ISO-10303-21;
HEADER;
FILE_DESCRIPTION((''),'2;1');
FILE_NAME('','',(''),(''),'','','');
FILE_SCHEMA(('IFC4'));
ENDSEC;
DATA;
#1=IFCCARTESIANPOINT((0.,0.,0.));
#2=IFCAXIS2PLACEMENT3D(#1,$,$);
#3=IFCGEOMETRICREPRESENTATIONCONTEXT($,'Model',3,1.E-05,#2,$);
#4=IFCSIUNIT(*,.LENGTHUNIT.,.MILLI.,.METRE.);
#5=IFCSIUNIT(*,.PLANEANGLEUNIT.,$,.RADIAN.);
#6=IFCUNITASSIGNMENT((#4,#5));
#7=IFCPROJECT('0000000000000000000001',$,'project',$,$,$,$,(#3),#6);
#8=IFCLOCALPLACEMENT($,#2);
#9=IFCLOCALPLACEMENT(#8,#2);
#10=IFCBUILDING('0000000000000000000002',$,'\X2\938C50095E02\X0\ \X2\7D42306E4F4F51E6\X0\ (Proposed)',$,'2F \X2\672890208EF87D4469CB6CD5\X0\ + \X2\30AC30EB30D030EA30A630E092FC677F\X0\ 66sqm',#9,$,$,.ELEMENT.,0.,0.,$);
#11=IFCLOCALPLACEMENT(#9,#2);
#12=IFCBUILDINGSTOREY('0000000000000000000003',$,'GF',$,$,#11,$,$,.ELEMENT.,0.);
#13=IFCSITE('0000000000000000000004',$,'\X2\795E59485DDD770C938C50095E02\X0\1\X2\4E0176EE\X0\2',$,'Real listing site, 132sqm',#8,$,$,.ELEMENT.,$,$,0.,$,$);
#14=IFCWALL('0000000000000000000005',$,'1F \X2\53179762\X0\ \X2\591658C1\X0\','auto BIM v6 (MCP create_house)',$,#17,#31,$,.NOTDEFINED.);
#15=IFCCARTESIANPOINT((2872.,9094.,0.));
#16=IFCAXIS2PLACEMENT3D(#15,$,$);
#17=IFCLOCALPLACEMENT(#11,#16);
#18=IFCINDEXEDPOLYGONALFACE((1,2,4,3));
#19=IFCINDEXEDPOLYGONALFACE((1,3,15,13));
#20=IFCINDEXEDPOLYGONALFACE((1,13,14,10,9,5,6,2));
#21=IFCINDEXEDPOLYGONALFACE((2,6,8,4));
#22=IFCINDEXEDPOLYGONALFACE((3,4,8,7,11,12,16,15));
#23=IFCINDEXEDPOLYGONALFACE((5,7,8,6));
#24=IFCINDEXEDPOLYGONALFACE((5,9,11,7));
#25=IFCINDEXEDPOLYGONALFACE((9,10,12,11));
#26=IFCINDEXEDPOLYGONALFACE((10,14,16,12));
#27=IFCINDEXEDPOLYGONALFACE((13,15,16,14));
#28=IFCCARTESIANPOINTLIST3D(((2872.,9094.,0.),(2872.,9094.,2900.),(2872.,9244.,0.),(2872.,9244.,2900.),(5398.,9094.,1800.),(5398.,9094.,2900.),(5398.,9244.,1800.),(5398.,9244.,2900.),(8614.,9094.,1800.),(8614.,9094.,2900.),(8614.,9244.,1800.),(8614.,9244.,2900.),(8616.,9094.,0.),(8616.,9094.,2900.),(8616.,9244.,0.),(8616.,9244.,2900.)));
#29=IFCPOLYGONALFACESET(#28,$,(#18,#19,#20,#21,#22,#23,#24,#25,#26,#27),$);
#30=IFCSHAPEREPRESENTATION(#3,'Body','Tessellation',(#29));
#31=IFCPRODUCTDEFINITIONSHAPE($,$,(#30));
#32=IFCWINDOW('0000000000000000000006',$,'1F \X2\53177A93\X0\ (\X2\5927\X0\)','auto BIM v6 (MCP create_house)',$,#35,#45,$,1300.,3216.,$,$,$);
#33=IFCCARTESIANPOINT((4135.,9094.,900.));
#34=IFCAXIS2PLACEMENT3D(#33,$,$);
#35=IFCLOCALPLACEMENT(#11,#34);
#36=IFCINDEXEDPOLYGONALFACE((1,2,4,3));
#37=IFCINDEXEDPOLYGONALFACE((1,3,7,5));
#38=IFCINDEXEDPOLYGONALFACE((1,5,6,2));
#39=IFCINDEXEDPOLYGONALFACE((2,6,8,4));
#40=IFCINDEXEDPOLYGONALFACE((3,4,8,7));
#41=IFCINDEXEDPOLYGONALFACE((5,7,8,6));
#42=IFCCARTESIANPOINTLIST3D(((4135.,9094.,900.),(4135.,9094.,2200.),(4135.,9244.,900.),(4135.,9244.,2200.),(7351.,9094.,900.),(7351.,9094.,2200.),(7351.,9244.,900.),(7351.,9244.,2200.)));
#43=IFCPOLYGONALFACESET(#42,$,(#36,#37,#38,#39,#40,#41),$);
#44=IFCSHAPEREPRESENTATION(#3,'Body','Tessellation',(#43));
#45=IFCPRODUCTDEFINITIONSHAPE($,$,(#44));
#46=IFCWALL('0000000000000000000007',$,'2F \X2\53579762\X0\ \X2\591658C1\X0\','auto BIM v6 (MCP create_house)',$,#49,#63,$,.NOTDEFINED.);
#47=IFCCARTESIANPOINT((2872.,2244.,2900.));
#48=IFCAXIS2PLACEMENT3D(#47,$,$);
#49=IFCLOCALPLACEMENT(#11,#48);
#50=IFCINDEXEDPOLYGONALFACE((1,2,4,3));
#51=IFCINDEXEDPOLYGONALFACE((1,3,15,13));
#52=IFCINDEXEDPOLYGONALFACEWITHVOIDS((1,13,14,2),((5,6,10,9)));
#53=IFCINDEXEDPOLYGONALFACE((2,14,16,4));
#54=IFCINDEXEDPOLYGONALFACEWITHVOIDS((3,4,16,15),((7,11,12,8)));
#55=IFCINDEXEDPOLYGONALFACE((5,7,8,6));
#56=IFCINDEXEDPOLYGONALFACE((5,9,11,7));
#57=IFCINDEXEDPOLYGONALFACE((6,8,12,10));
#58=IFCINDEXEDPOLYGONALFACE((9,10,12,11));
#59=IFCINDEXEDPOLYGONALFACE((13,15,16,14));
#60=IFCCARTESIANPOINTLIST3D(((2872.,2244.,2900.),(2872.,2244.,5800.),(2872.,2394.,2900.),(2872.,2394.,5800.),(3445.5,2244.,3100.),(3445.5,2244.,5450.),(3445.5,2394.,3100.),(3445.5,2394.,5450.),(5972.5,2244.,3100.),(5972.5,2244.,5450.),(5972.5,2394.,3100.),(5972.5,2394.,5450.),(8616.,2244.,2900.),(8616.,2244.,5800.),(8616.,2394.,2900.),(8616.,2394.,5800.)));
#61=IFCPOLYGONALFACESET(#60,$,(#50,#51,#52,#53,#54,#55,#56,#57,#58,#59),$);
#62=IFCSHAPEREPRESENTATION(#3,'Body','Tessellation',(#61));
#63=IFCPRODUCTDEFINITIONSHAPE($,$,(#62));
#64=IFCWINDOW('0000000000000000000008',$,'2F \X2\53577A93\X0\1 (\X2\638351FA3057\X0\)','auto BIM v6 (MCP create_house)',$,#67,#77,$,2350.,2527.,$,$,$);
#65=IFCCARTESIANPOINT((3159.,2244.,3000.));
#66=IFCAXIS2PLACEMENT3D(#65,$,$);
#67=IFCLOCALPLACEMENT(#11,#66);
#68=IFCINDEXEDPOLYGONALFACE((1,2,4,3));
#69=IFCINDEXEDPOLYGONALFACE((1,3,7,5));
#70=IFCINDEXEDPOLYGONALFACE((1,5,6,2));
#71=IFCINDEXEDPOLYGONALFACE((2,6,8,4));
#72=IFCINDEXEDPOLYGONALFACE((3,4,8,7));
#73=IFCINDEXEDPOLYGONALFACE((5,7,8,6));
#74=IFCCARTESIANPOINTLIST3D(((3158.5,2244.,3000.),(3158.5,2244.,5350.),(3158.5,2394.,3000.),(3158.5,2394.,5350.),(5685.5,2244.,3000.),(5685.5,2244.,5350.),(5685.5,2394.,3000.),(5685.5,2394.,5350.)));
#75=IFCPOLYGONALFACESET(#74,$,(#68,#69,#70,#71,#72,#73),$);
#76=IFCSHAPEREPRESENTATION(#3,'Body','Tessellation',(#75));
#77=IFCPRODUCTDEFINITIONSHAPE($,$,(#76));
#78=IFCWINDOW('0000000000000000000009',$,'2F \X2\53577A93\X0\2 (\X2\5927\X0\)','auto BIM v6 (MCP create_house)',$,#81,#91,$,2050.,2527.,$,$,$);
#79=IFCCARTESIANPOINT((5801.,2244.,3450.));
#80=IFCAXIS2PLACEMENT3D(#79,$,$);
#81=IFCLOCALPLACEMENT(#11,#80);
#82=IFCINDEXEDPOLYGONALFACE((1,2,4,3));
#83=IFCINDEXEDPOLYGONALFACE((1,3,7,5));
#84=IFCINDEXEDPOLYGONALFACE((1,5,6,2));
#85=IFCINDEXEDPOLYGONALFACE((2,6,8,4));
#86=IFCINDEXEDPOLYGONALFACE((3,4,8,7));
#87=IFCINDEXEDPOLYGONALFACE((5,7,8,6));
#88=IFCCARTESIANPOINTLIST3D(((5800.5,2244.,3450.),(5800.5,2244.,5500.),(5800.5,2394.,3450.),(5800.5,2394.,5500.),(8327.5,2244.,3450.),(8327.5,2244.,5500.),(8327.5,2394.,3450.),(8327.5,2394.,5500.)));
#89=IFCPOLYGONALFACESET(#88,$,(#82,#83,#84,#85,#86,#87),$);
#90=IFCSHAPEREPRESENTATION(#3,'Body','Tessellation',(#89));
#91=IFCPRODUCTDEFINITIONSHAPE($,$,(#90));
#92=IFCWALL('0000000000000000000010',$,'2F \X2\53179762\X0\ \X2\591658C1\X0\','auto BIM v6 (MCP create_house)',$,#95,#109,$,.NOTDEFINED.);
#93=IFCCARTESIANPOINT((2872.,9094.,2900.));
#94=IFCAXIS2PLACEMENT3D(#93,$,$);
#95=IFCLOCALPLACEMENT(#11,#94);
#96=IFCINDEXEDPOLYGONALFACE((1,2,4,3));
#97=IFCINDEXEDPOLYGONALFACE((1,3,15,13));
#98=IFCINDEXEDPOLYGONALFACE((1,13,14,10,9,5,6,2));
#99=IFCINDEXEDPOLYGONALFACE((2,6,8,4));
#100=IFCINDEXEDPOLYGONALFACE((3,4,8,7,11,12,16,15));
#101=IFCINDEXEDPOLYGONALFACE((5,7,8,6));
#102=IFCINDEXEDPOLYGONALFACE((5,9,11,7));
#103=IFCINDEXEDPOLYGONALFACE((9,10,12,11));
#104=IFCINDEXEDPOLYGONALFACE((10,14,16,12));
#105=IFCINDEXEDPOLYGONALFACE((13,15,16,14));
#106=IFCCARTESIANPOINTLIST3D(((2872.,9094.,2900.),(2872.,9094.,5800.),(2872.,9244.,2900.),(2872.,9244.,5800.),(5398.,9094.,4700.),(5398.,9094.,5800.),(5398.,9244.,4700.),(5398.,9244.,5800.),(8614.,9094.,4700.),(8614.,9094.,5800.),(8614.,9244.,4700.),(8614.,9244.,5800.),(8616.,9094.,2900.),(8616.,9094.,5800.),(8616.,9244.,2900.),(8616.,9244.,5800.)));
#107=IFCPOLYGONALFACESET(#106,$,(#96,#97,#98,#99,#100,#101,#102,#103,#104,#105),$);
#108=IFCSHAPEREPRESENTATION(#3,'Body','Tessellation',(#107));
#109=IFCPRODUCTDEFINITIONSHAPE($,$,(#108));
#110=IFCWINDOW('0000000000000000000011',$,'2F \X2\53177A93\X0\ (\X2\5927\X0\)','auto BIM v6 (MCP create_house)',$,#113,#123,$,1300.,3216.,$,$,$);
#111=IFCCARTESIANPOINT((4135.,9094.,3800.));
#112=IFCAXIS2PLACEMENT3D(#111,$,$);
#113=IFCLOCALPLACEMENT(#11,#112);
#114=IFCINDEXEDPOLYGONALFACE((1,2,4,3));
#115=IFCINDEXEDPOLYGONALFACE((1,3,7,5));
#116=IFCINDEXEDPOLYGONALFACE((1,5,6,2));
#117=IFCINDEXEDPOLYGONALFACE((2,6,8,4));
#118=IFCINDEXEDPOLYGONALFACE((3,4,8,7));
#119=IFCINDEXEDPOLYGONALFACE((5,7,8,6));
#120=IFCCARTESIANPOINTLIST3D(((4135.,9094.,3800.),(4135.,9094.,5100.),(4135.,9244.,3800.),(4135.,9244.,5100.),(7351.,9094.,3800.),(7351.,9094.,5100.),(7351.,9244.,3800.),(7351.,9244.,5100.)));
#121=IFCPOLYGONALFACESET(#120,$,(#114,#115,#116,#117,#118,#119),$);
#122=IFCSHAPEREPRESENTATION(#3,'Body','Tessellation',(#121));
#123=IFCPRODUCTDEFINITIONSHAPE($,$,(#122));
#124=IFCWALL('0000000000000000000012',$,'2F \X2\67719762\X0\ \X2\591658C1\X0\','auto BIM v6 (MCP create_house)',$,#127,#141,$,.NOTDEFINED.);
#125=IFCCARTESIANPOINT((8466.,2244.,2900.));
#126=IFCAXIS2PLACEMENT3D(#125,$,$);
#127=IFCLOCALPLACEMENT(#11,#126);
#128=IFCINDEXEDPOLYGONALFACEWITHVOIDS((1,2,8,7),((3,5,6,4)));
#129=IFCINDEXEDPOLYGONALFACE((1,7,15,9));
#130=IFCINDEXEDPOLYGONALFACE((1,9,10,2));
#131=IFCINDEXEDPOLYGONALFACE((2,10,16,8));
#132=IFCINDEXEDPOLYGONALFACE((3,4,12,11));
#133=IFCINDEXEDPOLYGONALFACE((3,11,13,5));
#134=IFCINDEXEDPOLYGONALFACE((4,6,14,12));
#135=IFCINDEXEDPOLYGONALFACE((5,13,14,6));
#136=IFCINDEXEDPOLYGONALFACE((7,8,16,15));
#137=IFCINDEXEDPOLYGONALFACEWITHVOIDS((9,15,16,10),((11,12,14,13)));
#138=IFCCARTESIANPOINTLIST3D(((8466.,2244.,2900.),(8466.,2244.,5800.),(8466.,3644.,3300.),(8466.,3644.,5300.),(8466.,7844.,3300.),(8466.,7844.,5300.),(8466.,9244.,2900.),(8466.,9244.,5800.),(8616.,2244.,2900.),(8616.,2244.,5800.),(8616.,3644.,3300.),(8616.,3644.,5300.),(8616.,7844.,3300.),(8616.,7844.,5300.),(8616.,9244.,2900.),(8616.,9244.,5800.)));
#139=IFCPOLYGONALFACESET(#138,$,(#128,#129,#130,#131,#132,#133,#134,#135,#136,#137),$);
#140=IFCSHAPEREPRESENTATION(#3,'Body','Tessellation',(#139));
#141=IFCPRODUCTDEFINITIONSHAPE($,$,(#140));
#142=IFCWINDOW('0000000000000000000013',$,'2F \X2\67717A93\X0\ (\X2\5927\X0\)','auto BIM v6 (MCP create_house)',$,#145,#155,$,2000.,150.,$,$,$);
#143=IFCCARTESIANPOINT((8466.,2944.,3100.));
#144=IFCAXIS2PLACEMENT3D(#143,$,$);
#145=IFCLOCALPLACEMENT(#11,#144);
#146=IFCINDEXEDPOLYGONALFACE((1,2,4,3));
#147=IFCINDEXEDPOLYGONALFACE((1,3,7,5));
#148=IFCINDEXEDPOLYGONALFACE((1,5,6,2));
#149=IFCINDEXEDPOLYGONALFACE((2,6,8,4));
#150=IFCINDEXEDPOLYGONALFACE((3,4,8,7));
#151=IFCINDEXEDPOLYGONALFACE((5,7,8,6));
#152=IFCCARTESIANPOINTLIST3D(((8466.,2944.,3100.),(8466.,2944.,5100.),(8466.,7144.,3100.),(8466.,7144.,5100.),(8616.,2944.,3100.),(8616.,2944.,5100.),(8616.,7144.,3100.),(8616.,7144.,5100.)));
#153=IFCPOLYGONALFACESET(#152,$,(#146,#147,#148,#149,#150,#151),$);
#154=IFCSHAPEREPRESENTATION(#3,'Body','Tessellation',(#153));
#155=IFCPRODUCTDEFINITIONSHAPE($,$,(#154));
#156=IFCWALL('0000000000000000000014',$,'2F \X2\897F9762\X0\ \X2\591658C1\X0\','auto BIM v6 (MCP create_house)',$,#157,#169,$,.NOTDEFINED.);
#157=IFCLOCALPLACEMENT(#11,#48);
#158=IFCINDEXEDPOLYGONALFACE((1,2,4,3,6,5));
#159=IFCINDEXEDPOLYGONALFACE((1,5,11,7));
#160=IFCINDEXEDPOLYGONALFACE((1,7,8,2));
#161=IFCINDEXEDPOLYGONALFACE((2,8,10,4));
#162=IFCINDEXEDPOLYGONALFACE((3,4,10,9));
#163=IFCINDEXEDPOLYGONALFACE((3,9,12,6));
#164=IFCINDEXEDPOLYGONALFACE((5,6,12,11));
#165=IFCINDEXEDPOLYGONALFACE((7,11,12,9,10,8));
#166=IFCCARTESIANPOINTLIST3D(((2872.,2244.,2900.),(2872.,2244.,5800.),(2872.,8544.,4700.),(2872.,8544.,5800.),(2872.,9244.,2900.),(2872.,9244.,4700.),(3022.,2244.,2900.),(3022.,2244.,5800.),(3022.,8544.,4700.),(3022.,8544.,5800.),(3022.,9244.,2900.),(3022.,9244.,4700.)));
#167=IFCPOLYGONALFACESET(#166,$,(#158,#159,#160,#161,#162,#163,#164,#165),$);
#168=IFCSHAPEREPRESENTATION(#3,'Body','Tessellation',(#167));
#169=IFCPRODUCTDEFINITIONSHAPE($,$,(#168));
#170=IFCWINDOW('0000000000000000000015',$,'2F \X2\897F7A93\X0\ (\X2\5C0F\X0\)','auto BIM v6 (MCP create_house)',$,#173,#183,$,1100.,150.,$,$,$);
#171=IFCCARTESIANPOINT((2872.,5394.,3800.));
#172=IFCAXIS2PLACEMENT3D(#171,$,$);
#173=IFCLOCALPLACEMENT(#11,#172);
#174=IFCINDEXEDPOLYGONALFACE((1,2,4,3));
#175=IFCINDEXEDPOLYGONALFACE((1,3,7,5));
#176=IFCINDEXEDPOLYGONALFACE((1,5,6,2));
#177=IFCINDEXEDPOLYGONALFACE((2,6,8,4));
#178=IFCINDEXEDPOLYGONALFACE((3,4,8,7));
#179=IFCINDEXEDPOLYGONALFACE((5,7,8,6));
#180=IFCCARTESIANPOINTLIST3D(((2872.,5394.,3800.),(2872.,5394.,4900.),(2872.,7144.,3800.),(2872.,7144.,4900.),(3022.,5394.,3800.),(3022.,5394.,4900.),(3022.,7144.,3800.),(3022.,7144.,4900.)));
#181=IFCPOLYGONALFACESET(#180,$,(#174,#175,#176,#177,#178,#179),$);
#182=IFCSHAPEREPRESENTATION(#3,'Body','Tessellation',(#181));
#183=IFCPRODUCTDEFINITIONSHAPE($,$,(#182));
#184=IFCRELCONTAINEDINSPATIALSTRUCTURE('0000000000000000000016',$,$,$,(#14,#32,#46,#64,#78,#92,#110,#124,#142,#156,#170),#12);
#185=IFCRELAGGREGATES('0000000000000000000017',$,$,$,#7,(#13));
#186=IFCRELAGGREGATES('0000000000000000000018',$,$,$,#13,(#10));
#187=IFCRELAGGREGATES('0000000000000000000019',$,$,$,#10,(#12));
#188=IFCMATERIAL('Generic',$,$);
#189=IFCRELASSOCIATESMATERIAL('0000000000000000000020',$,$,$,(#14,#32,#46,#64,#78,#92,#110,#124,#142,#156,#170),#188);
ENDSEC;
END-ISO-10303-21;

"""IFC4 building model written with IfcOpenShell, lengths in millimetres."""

from ifc_helpers import new_model, si_unit, frame, frame_2d, origin, place, context, project, spatial, rectangle, extrude, material, element, fill, save


model = new_model("IFC4")

# Units and contexts
model_context = context("Model", 3, precision=1e-05, world=origin())
ifc_project = project(units=[si_unit("LENGTHUNIT", "METRE", prefix="MILLI"), si_unit("PLANEANGLEUNIT", "RADIAN")], contexts=[model_context])

# Site, building, storey
site_placement = place(None, origin())
site = spatial("IfcSite", under=ifc_project, at=site_placement, Name="神奈川県鎌倉市1丁目2", ObjectType="Real listing site, 132sqm", CompositionType="ELEMENT", RefElevation=0.0)
building_placement = place(site_placement, origin())
building = spatial("IfcBuilding", under=site, at=building_placement, Name="鎌倉市 終の住処 (Proposed)", ObjectType="2F 木造軸組構法 + ガルバリウム鋼板 66sqm", CompositionType="ELEMENT", ElevationOfRefHeight=0.0, ElevationOfTerrain=0.0)
storey_placement = place(building_placement, origin())
storey = spatial("IfcBuildingStorey", under=building, at=storey_placement, Name="GF", CompositionType="ELEMENT", Elevation=0.0)

# Wall, opening, window
ifc_material = material(Name="Generic")
wall_1_placement = place(storey_placement, frame((2872.0, 9094.0, 0.0)))
wall_1 = element("IfcWall", 1, at=wall_1_placement, inside=storey, material=ifc_material, Name="1F 北面 外壁", Description="auto BIM v6 (MCP create_house)", PredefinedType="NOTDEFINED", context=model_context, shape_type="SweptSolid", body=[
    extrude(rectangle(XDim=5744.0, YDim=150.0, at=frame_2d((2872.0, 75.0))), frame((2872.0, 9094.0, 0.0)), (0.0, 0.0, 1.0), 2900.0),
])
opening_1_placement = place(storey_placement, frame((4135.0, 9094.0, 900.0)))
opening_1 = element("IfcOpeningElement", 2, at=opening_1_placement, cuts=wall_1, PredefinedType="NOTDEFINED", context=model_context, shape_type="SweptSolid", body=[
    extrude(rectangle(XDim=3216.0, YDim=150.0, at=frame_2d((1608.0, 75.0))), frame((4135.0, 9094.0, 900.0)), (0.0, 0.0, 1.0), 1300.0),
])
window_1_placement = place(storey_placement, frame((4135.0, 9094.0, 900.0)))
window_1 = element("IfcWindow", 3, at=window_1_placement, inside=storey, material=ifc_material, Name="1F 北窓 (大)", Description="auto BIM v6 (MCP create_house)", OverallHeight=1300.0, OverallWidth=3216.0, context=model_context, shape_type="SweptSolid", body=[
    extrude(rectangle(XDim=3216.0, YDim=150.0, at=frame_2d((1608.0, 75.0))), frame((4135.0, 9094.0, 900.0)), (0.0, 0.0, 1.0), 1300.0),
])
fill(opening_1, window_1)

# Wall, openings, windows
wall_2_placement = place(storey_placement, frame((2872.0, 2244.0, 2900.0)))
wall_2 = element("IfcWall", 4, at=wall_2_placement, inside=storey, material=ifc_material, Name="2F 南面 外壁", Description="auto BIM v6 (MCP create_house)", PredefinedType="NOTDEFINED", context=model_context, shape_type="SweptSolid", body=[
    extrude(rectangle(XDim=5744.0, YDim=150.0, at=frame_2d((2872.0, 75.0))), frame((2872.0, 2244.0, 2900.0)), (0.0, 0.0, 1.0), 2900.0),
])
opening_2_placement = place(storey_placement, frame((3159.0, 2244.0, 3000.0)))
opening_2 = element("IfcOpeningElement", 5, at=opening_2_placement, cuts=wall_2, PredefinedType="NOTDEFINED", context=model_context, shape_type="SweptSolid", body=[
    extrude(rectangle(XDim=2527.0, YDim=150.0, at=frame_2d((1263.0, 75.0))), frame((3159.0, 2244.0, 3000.0)), (0.0, 0.0, 1.0), 2350.0),
])
opening_3_placement = place(storey_placement, frame((5801.0, 2244.0, 3450.0)))
opening_3 = element("IfcOpeningElement", 6, at=opening_3_placement, cuts=wall_2, PredefinedType="NOTDEFINED", context=model_context, shape_type="SweptSolid", body=[
    extrude(rectangle(XDim=2527.0, YDim=150.0, at=frame_2d((1263.0, 75.0))), frame((5801.0, 2244.0, 3450.0)), (0.0, 0.0, 1.0), 2050.0),
])
window_2_placement = place(storey_placement, frame((3159.0, 2244.0, 3000.0)))
window_2 = element("IfcWindow", 7, at=window_2_placement, inside=storey, material=ifc_material, Name="2F 南窓1 (掃出し)", Description="auto BIM v6 (MCP create_house)", OverallHeight=2350.0, OverallWidth=2527.0, context=model_context, shape_type="SweptSolid", body=[
    extrude(rectangle(XDim=2527.0, YDim=150.0, at=frame_2d((1263.0, 75.0))), frame((3159.0, 2244.0, 3000.0)), (0.0, 0.0, 1.0), 2350.0),
])
fill(opening_2, window_2)
window_3_placement = place(storey_placement, frame((5801.0, 2244.0, 3450.0)))
window_3 = element("IfcWindow", 8, at=window_3_placement, inside=storey, material=ifc_material, Name="2F 南窓2 (大)", Description="auto BIM v6 (MCP create_house)", OverallHeight=2050.0, OverallWidth=2527.0, context=model_context, shape_type="SweptSolid", body=[
    extrude(rectangle(XDim=2527.0, YDim=150.0, at=frame_2d((1263.0, 75.0))), frame((5801.0, 2244.0, 3450.0)), (0.0, 0.0, 1.0), 2050.0),
])
fill(opening_3, window_3)

# Walls, openings, windows
wall_3_placement = place(storey_placement, frame((2872.0, 9094.0, 2900.0)))
wall_3 = element("IfcWall", 9, at=wall_3_placement, inside=storey, material=ifc_material, Name="2F 北面 外壁", Description="auto BIM v6 (MCP create_house)", PredefinedType="NOTDEFINED", context=model_context, shape_type="SweptSolid", body=[
    extrude(rectangle(XDim=5744.0, YDim=150.0, at=frame_2d((2872.0, 75.0))), frame((2872.0, 9094.0, 2900.0)), (0.0, 0.0, 1.0), 2900.0),
])
opening_4_placement = place(storey_placement, frame((4135.0, 9094.0, 3800.0)))
opening_4 = element("IfcOpeningElement", 10, at=opening_4_placement, cuts=wall_3, PredefinedType="NOTDEFINED", context=model_context, shape_type="SweptSolid", body=[
    extrude(rectangle(XDim=3216.0, YDim=150.0, at=frame_2d((1608.0, 75.0))), frame((4135.0, 9094.0, 3800.0)), (0.0, 0.0, 1.0), 1300.0),
])
window_4_placement = place(storey_placement, frame((4135.0, 9094.0, 3800.0)))
window_4 = element("IfcWindow", 11, at=window_4_placement, inside=storey, material=ifc_material, Name="2F 北窓 (大)", Description="auto BIM v6 (MCP create_house)", OverallHeight=1300.0, OverallWidth=3216.0, context=model_context, shape_type="SweptSolid", body=[
    extrude(rectangle(XDim=3216.0, YDim=150.0, at=frame_2d((1608.0, 75.0))), frame((4135.0, 9094.0, 3800.0)), (0.0, 0.0, 1.0), 1300.0),
])
fill(opening_4, window_4)
wall_4_placement = place(storey_placement, frame((8466.0, 2244.0, 2900.0)))
wall_4 = element("IfcWall", 12, at=wall_4_placement, inside=storey, material=ifc_material, Name="2F 東面 外壁", Description="auto BIM v6 (MCP create_house)", PredefinedType="NOTDEFINED", context=model_context, shape_type="SweptSolid", body=[
    extrude(rectangle(XDim=150.0, YDim=7000.0, at=frame_2d((75.0, 3500.0))), frame((8466.0, 2244.0, 2900.0)), (0.0, 0.0, 1.0), 2900.0),
])
opening_5_placement = place(storey_placement, frame((8466.0, 2944.0, 3100.0)))
opening_5 = element("IfcOpeningElement", 13, at=opening_5_placement, cuts=wall_4, PredefinedType="NOTDEFINED", context=model_context, shape_type="SweptSolid", body=[
    extrude(rectangle(XDim=150.0, YDim=4200.0, at=frame_2d((75.0, 2100.0))), frame((8466.0, 2944.0, 3100.0)), (0.0, 0.0, 1.0), 2000.0),
])
window_5_placement = place(storey_placement, frame((8466.0, 2944.0, 3100.0)))
window_5 = element("IfcWindow", 14, at=window_5_placement, inside=storey, material=ifc_material, Name="2F 東窓 (大)", Description="auto BIM v6 (MCP create_house)", OverallHeight=2000.0, OverallWidth=150.0, context=model_context, shape_type="SweptSolid", body=[
    extrude(rectangle(XDim=150.0, YDim=4200.0, at=frame_2d((75.0, 2100.0))), frame((8466.0, 2944.0, 3100.0)), (0.0, 0.0, 1.0), 2000.0),
])
fill(opening_5, window_5)
wall_5_placement = place(storey_placement, frame((2872.0, 2244.0, 2900.0)))
wall_5 = element("IfcWall", 15, at=wall_5_placement, inside=storey, material=ifc_material, Name="2F 西面 外壁", Description="auto BIM v6 (MCP create_house)", PredefinedType="NOTDEFINED", context=model_context, shape_type="SweptSolid", body=[
    extrude(rectangle(XDim=150.0, YDim=7000.0, at=frame_2d((75.0, 3500.0))), frame((2872.0, 2244.0, 2900.0)), (0.0, 0.0, 1.0), 2900.0),
])
opening_6_placement = place(storey_placement, frame((2872.0, 5394.0, 3800.0)))
opening_6 = element("IfcOpeningElement", 16, at=opening_6_placement, cuts=wall_5, PredefinedType="NOTDEFINED", context=model_context, shape_type="SweptSolid", body=[
    extrude(rectangle(XDim=150.0, YDim=1750.0, at=frame_2d((75.0, 875.0))), frame((2872.0, 5394.0, 3800.0)), (0.0, 0.0, 1.0), 1100.0),
])
window_6_placement = place(storey_placement, frame((2872.0, 5394.0, 3800.0)))
window_6 = element("IfcWindow", 17, at=window_6_placement, inside=storey, material=ifc_material, Name="2F 西窓 (小)", Description="auto BIM v6 (MCP create_house)", OverallHeight=1100.0, OverallWidth=150.0, context=model_context, shape_type="SweptSolid", body=[
    extrude(rectangle(XDim=150.0, YDim=1750.0, at=frame_2d((75.0, 875.0))), frame((2872.0, 5394.0, 3800.0)), (0.0, 0.0, 1.0), 1100.0),
])
fill(opening_6, window_6)

save(model, "model.ifc")
